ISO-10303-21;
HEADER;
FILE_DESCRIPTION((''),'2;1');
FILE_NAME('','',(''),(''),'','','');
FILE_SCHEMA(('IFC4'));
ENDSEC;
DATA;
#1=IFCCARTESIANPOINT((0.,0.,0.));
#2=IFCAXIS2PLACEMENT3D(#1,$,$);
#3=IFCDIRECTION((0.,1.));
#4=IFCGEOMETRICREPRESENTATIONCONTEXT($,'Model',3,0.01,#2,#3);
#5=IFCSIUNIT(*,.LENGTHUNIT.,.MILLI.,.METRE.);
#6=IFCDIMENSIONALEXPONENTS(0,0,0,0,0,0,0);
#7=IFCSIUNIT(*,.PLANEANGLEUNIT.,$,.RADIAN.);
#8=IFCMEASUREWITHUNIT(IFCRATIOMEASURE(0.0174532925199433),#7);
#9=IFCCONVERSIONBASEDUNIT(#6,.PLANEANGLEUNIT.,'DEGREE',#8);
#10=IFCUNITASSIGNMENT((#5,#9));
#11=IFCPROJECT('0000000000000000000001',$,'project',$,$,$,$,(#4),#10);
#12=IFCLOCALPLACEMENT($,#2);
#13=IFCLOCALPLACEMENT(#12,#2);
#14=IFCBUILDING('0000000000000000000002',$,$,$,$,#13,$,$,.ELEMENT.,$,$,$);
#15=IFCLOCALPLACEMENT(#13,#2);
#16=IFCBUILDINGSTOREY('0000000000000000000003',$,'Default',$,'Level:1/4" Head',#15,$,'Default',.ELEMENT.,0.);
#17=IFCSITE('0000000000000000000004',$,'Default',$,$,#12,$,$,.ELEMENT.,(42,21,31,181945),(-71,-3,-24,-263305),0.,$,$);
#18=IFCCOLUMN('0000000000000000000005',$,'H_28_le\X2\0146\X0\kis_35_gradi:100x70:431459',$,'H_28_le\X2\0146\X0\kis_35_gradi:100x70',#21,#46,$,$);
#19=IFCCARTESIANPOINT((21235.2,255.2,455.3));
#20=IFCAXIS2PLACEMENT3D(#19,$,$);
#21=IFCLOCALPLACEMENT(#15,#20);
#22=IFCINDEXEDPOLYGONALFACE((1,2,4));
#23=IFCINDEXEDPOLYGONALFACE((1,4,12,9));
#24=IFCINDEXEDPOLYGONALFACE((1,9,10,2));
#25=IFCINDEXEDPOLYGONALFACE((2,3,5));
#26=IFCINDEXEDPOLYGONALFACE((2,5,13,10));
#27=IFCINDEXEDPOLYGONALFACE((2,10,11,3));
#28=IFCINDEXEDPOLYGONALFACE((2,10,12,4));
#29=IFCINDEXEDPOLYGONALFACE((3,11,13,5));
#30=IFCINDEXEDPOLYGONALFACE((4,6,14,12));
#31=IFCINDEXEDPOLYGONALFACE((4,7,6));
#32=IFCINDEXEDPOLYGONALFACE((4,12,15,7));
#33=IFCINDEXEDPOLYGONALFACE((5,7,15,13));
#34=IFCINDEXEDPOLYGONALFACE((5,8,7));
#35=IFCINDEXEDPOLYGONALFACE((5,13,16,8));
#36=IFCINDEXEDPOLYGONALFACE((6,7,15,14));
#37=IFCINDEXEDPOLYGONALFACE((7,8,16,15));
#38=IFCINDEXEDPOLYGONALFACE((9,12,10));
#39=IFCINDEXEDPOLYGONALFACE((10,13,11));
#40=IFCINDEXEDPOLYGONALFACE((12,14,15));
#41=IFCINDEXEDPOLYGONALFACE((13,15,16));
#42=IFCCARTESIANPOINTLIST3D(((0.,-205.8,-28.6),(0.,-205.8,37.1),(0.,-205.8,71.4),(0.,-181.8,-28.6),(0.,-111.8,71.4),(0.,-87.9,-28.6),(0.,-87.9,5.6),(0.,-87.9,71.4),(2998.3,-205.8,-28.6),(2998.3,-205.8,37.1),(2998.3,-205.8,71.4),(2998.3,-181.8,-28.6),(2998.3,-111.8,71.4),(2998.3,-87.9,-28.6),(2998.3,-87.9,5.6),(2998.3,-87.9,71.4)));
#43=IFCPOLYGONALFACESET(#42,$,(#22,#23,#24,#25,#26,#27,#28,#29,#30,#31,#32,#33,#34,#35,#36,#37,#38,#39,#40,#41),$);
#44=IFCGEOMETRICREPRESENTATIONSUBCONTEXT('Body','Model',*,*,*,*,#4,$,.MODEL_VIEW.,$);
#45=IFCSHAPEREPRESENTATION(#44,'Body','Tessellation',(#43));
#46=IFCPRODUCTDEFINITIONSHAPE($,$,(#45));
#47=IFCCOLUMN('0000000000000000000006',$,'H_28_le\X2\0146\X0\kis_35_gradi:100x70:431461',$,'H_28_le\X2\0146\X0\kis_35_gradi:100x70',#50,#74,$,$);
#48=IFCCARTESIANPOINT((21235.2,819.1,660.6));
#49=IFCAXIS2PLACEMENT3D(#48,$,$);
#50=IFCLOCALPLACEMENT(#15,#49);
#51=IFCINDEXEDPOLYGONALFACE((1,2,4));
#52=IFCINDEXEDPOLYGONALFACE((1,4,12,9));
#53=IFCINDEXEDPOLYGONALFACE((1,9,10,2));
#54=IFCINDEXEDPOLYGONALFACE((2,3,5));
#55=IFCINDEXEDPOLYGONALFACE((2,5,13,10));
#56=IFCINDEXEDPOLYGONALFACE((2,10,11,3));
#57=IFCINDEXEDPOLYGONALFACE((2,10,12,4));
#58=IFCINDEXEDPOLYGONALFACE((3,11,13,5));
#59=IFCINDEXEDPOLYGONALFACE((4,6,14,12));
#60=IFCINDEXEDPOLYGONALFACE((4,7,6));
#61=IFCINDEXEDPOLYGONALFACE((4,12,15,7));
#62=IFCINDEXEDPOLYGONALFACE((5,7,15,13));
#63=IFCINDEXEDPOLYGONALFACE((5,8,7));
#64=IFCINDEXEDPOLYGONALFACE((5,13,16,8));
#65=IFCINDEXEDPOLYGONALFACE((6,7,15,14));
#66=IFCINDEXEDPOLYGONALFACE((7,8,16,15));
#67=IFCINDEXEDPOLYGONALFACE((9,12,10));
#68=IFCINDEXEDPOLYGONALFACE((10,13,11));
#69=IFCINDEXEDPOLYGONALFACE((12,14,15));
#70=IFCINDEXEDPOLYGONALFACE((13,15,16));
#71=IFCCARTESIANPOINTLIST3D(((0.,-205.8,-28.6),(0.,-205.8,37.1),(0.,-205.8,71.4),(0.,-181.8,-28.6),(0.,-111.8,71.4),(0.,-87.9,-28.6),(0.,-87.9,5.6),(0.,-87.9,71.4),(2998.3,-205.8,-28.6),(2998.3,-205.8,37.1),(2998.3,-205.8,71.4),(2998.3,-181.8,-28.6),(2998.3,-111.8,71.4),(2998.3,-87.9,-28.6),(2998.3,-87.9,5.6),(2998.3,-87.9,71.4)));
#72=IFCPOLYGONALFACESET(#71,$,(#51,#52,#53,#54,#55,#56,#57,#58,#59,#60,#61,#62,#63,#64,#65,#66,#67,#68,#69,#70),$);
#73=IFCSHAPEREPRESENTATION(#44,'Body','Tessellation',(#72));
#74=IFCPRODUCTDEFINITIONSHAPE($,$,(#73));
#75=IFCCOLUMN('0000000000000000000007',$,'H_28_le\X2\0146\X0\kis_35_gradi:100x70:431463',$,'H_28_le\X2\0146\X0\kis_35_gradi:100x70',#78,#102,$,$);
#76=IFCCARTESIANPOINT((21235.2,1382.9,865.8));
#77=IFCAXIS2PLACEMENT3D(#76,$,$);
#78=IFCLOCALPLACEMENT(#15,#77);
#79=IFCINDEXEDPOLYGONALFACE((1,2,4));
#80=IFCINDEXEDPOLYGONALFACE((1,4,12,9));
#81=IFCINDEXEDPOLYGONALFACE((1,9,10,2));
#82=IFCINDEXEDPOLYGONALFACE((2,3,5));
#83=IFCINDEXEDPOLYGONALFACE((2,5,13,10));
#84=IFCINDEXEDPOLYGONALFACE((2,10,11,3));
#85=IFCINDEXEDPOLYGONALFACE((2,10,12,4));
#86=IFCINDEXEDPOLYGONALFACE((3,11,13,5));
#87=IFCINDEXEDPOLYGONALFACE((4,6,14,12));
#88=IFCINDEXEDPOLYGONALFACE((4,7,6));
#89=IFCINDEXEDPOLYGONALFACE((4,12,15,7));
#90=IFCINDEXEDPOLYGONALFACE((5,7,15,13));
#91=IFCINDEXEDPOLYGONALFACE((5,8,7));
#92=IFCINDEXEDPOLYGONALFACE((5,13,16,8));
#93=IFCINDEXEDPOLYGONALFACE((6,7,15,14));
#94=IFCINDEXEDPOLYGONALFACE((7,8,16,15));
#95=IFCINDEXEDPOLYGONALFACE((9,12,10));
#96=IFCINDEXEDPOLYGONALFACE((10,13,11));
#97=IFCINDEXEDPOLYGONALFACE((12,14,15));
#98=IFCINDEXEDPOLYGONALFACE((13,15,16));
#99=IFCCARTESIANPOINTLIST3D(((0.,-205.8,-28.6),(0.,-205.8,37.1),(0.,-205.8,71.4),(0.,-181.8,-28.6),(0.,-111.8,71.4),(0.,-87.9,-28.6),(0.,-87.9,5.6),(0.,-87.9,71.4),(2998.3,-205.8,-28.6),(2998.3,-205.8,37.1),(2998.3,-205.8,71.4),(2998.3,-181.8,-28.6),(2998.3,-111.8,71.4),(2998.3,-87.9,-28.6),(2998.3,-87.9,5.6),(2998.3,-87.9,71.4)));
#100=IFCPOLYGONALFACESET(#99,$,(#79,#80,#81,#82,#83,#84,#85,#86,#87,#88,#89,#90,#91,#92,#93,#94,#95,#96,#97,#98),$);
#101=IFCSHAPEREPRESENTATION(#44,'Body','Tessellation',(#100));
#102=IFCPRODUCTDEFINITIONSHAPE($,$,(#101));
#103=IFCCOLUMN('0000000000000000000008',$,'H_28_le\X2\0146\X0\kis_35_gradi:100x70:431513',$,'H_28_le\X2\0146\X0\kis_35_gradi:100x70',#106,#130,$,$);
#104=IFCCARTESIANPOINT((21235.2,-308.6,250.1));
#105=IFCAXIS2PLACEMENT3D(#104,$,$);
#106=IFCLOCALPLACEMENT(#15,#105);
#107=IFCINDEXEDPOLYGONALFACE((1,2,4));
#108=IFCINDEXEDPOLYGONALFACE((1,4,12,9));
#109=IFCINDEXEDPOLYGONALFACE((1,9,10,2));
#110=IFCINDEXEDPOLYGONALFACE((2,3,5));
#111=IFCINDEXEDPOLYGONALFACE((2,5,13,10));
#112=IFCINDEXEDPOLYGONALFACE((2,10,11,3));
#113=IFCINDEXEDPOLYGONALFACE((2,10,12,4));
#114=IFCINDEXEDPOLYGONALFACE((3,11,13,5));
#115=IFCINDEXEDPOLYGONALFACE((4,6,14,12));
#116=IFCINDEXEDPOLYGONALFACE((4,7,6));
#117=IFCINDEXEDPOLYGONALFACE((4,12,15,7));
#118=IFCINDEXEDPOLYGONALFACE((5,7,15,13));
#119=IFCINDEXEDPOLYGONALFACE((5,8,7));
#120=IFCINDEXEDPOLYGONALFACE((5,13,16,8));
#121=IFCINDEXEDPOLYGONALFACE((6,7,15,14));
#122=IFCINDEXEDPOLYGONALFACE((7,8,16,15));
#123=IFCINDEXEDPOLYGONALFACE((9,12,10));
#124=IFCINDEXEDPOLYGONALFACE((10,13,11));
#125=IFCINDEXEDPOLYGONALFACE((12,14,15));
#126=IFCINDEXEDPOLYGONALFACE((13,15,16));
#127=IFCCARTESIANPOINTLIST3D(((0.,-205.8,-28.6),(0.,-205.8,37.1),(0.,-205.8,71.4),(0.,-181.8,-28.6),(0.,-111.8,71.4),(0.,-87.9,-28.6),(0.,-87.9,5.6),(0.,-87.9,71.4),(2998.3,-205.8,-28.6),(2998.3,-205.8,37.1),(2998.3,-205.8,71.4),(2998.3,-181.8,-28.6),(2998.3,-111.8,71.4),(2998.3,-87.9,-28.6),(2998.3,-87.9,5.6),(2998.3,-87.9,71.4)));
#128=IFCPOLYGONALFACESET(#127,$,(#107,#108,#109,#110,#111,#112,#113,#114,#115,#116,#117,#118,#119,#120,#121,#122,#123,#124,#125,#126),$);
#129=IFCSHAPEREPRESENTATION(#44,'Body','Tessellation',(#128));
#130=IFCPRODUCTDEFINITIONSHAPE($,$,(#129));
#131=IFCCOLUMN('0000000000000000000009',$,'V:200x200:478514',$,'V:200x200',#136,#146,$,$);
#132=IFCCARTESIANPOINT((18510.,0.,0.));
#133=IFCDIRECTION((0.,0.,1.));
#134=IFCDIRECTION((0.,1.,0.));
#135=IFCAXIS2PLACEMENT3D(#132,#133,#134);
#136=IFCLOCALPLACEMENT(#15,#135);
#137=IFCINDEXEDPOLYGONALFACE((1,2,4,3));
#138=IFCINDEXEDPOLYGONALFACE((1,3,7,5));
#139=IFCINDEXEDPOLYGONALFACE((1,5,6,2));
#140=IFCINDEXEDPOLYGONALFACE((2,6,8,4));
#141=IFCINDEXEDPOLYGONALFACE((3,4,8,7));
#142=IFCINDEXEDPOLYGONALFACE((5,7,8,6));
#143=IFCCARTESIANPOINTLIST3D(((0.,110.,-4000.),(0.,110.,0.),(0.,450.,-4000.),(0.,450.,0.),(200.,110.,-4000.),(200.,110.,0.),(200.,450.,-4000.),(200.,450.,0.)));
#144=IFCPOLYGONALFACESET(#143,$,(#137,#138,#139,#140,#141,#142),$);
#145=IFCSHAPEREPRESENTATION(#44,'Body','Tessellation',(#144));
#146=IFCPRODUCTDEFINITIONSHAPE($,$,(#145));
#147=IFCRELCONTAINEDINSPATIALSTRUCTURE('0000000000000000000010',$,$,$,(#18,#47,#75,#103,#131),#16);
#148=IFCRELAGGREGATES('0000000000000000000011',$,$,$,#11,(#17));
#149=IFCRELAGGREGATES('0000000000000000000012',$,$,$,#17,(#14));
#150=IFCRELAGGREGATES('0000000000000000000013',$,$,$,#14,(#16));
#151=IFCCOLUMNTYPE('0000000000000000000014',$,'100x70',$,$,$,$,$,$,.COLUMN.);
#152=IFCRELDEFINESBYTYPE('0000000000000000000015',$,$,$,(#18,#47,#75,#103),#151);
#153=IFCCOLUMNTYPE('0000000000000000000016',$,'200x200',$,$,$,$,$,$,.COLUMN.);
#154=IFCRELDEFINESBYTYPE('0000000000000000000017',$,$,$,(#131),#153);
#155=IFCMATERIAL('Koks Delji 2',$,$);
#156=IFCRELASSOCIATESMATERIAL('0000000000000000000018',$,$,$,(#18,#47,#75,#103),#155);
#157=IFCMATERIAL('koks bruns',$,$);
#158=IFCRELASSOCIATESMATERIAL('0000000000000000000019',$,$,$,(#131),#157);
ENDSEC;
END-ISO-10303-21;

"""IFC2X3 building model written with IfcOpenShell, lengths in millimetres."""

from ifc_helpers import new_model, entity, si_unit, converted_unit, direction, frame, frame_2d, origin, origin_2d_with_axis, place, context, subcontext, project, spatial, rectangle, extrude, boolean, source, transform, mapped, material, type_object, type_shapes, element, save


model = new_model("IFC2X3")

# Units and contexts
model_context = context("Model", 3, precision=0.01, world=origin(), true_north=direction((0.0, 1.0)))
body_context = subcontext(model_context, "Body", "Model", "MODEL_VIEW")
ifc_project = project(units=[si_unit("LENGTHUNIT", "METRE", prefix="MILLI"), converted_unit("PLANEANGLEUNIT", "DEGREE", entity("IfcRatioMeasure", 0.0174532925199433), si_unit("PLANEANGLEUNIT", "RADIAN"), dimensions=[0, 0, 0, 0, 0, 0, 0])], contexts=[model_context])

# Site, building, storey
site_placement = place(None, origin())
site = spatial("IfcSite", under=ifc_project, at=site_placement, Name="Default", CompositionType="ELEMENT", RefLatitude=(42, 21, 31, 181945), RefLongitude=(-71, -3, -24, -263305), RefElevation=0.0)
building_placement = place(site_placement, origin())
building = spatial("IfcBuilding", under=site, at=building_placement, CompositionType="ELEMENT")
storey_placement = place(building_placement, origin())
storey = spatial("IfcBuildingStorey", under=building, at=storey_placement, Name="Default", ObjectType="Level:1/4\" Head", LongName="Default", CompositionType="ELEMENT", Elevation=0.0)

# Columns
ifc_material_1 = material(Name="Koks Delji 2")
column_type_1 = type_object("IfcColumnType", Name="100x70", PredefinedType="COLUMN")
shared_shape_1 = source(origin(), body_context, "Body", "CSG", [
    boolean("DIFFERENCE", extrude(rectangle(XDim=2998.3, YDim=117.9, at=frame_2d((0.0, 0.0), x_axis=(1.0, 0.0))), frame((1499.1, -146.8, -28.6)), (0.0, 0.0, 1.0), 100.0), extrude(rectangle(XDim=70.0, YDim=100.0, at=frame_2d((0.0, 0.0), x_axis=(0.0, 1.0))), frame((0.0, -146.8, 21.4), z_axis=(-1.0, 0.0, 0.0), x_axis=(0.0, -0.939693, -0.34202)), (0.0, 0.0, -1.0), 2998.3)),
])
type_shapes(column_type_1, [shared_shape_1])
for number, where, name in (
    (1, (21235.2, 255.2, 455.3), "H_28_leņkis_35_gradi:100x70:431459"),
    (2, (21235.2, 819.1, 660.6), "H_28_leņkis_35_gradi:100x70:431461"),
    (3, (21235.2, 1382.9, 865.8), "H_28_leņkis_35_gradi:100x70:431463"),
    (4, (21235.2, -308.6, 250.1), "H_28_leņkis_35_gradi:100x70:431513"),
):
    element("IfcColumn", number, at=place(storey_placement, frame(where)), inside=storey, type_object=column_type_1, material=ifc_material_1, Name=name, ObjectType="H_28_leņkis_35_gradi:100x70", context=body_context, shape_type="MappedRepresentation", body=[
        mapped(shared_shape_1, transform((0.0, 0.0, 0.0), scale=1.0)),
    ])
ifc_material_2 = material(Name="koks bruns")
column_type_2 = type_object("IfcColumnType", Name="200x200", PredefinedType="COLUMN")
shared_shape_2 = source(origin(), body_context, "Body", "SweptSolid", [
    extrude(rectangle(XDim=340.0, YDim=200.0, at=origin_2d_with_axis()), frame((100.0, 280.0, -4000.0), z_axis=(0.0, 0.0, 1.0), x_axis=(0.0, -1.0, 0.0)), (0.0, 0.0, 1.0), 4000.0),
])
type_shapes(column_type_2, [shared_shape_2])
column_placement = place(storey_placement, frame((18510.0, 0.0, 0.0), z_axis=(0.0, 0.0, 1.0), x_axis=(0.0, 1.0, 0.0)))
element("IfcColumn", 5, at=column_placement, inside=storey, type_object=column_type_2, material=ifc_material_2, Name="V:200x200:478514", ObjectType="V:200x200", context=body_context, shape_type="MappedRepresentation", body=[
    mapped(shared_shape_2, transform((0.0, 0.0, 0.0), scale=1.0)),
])

save(model, "model.ifc")
